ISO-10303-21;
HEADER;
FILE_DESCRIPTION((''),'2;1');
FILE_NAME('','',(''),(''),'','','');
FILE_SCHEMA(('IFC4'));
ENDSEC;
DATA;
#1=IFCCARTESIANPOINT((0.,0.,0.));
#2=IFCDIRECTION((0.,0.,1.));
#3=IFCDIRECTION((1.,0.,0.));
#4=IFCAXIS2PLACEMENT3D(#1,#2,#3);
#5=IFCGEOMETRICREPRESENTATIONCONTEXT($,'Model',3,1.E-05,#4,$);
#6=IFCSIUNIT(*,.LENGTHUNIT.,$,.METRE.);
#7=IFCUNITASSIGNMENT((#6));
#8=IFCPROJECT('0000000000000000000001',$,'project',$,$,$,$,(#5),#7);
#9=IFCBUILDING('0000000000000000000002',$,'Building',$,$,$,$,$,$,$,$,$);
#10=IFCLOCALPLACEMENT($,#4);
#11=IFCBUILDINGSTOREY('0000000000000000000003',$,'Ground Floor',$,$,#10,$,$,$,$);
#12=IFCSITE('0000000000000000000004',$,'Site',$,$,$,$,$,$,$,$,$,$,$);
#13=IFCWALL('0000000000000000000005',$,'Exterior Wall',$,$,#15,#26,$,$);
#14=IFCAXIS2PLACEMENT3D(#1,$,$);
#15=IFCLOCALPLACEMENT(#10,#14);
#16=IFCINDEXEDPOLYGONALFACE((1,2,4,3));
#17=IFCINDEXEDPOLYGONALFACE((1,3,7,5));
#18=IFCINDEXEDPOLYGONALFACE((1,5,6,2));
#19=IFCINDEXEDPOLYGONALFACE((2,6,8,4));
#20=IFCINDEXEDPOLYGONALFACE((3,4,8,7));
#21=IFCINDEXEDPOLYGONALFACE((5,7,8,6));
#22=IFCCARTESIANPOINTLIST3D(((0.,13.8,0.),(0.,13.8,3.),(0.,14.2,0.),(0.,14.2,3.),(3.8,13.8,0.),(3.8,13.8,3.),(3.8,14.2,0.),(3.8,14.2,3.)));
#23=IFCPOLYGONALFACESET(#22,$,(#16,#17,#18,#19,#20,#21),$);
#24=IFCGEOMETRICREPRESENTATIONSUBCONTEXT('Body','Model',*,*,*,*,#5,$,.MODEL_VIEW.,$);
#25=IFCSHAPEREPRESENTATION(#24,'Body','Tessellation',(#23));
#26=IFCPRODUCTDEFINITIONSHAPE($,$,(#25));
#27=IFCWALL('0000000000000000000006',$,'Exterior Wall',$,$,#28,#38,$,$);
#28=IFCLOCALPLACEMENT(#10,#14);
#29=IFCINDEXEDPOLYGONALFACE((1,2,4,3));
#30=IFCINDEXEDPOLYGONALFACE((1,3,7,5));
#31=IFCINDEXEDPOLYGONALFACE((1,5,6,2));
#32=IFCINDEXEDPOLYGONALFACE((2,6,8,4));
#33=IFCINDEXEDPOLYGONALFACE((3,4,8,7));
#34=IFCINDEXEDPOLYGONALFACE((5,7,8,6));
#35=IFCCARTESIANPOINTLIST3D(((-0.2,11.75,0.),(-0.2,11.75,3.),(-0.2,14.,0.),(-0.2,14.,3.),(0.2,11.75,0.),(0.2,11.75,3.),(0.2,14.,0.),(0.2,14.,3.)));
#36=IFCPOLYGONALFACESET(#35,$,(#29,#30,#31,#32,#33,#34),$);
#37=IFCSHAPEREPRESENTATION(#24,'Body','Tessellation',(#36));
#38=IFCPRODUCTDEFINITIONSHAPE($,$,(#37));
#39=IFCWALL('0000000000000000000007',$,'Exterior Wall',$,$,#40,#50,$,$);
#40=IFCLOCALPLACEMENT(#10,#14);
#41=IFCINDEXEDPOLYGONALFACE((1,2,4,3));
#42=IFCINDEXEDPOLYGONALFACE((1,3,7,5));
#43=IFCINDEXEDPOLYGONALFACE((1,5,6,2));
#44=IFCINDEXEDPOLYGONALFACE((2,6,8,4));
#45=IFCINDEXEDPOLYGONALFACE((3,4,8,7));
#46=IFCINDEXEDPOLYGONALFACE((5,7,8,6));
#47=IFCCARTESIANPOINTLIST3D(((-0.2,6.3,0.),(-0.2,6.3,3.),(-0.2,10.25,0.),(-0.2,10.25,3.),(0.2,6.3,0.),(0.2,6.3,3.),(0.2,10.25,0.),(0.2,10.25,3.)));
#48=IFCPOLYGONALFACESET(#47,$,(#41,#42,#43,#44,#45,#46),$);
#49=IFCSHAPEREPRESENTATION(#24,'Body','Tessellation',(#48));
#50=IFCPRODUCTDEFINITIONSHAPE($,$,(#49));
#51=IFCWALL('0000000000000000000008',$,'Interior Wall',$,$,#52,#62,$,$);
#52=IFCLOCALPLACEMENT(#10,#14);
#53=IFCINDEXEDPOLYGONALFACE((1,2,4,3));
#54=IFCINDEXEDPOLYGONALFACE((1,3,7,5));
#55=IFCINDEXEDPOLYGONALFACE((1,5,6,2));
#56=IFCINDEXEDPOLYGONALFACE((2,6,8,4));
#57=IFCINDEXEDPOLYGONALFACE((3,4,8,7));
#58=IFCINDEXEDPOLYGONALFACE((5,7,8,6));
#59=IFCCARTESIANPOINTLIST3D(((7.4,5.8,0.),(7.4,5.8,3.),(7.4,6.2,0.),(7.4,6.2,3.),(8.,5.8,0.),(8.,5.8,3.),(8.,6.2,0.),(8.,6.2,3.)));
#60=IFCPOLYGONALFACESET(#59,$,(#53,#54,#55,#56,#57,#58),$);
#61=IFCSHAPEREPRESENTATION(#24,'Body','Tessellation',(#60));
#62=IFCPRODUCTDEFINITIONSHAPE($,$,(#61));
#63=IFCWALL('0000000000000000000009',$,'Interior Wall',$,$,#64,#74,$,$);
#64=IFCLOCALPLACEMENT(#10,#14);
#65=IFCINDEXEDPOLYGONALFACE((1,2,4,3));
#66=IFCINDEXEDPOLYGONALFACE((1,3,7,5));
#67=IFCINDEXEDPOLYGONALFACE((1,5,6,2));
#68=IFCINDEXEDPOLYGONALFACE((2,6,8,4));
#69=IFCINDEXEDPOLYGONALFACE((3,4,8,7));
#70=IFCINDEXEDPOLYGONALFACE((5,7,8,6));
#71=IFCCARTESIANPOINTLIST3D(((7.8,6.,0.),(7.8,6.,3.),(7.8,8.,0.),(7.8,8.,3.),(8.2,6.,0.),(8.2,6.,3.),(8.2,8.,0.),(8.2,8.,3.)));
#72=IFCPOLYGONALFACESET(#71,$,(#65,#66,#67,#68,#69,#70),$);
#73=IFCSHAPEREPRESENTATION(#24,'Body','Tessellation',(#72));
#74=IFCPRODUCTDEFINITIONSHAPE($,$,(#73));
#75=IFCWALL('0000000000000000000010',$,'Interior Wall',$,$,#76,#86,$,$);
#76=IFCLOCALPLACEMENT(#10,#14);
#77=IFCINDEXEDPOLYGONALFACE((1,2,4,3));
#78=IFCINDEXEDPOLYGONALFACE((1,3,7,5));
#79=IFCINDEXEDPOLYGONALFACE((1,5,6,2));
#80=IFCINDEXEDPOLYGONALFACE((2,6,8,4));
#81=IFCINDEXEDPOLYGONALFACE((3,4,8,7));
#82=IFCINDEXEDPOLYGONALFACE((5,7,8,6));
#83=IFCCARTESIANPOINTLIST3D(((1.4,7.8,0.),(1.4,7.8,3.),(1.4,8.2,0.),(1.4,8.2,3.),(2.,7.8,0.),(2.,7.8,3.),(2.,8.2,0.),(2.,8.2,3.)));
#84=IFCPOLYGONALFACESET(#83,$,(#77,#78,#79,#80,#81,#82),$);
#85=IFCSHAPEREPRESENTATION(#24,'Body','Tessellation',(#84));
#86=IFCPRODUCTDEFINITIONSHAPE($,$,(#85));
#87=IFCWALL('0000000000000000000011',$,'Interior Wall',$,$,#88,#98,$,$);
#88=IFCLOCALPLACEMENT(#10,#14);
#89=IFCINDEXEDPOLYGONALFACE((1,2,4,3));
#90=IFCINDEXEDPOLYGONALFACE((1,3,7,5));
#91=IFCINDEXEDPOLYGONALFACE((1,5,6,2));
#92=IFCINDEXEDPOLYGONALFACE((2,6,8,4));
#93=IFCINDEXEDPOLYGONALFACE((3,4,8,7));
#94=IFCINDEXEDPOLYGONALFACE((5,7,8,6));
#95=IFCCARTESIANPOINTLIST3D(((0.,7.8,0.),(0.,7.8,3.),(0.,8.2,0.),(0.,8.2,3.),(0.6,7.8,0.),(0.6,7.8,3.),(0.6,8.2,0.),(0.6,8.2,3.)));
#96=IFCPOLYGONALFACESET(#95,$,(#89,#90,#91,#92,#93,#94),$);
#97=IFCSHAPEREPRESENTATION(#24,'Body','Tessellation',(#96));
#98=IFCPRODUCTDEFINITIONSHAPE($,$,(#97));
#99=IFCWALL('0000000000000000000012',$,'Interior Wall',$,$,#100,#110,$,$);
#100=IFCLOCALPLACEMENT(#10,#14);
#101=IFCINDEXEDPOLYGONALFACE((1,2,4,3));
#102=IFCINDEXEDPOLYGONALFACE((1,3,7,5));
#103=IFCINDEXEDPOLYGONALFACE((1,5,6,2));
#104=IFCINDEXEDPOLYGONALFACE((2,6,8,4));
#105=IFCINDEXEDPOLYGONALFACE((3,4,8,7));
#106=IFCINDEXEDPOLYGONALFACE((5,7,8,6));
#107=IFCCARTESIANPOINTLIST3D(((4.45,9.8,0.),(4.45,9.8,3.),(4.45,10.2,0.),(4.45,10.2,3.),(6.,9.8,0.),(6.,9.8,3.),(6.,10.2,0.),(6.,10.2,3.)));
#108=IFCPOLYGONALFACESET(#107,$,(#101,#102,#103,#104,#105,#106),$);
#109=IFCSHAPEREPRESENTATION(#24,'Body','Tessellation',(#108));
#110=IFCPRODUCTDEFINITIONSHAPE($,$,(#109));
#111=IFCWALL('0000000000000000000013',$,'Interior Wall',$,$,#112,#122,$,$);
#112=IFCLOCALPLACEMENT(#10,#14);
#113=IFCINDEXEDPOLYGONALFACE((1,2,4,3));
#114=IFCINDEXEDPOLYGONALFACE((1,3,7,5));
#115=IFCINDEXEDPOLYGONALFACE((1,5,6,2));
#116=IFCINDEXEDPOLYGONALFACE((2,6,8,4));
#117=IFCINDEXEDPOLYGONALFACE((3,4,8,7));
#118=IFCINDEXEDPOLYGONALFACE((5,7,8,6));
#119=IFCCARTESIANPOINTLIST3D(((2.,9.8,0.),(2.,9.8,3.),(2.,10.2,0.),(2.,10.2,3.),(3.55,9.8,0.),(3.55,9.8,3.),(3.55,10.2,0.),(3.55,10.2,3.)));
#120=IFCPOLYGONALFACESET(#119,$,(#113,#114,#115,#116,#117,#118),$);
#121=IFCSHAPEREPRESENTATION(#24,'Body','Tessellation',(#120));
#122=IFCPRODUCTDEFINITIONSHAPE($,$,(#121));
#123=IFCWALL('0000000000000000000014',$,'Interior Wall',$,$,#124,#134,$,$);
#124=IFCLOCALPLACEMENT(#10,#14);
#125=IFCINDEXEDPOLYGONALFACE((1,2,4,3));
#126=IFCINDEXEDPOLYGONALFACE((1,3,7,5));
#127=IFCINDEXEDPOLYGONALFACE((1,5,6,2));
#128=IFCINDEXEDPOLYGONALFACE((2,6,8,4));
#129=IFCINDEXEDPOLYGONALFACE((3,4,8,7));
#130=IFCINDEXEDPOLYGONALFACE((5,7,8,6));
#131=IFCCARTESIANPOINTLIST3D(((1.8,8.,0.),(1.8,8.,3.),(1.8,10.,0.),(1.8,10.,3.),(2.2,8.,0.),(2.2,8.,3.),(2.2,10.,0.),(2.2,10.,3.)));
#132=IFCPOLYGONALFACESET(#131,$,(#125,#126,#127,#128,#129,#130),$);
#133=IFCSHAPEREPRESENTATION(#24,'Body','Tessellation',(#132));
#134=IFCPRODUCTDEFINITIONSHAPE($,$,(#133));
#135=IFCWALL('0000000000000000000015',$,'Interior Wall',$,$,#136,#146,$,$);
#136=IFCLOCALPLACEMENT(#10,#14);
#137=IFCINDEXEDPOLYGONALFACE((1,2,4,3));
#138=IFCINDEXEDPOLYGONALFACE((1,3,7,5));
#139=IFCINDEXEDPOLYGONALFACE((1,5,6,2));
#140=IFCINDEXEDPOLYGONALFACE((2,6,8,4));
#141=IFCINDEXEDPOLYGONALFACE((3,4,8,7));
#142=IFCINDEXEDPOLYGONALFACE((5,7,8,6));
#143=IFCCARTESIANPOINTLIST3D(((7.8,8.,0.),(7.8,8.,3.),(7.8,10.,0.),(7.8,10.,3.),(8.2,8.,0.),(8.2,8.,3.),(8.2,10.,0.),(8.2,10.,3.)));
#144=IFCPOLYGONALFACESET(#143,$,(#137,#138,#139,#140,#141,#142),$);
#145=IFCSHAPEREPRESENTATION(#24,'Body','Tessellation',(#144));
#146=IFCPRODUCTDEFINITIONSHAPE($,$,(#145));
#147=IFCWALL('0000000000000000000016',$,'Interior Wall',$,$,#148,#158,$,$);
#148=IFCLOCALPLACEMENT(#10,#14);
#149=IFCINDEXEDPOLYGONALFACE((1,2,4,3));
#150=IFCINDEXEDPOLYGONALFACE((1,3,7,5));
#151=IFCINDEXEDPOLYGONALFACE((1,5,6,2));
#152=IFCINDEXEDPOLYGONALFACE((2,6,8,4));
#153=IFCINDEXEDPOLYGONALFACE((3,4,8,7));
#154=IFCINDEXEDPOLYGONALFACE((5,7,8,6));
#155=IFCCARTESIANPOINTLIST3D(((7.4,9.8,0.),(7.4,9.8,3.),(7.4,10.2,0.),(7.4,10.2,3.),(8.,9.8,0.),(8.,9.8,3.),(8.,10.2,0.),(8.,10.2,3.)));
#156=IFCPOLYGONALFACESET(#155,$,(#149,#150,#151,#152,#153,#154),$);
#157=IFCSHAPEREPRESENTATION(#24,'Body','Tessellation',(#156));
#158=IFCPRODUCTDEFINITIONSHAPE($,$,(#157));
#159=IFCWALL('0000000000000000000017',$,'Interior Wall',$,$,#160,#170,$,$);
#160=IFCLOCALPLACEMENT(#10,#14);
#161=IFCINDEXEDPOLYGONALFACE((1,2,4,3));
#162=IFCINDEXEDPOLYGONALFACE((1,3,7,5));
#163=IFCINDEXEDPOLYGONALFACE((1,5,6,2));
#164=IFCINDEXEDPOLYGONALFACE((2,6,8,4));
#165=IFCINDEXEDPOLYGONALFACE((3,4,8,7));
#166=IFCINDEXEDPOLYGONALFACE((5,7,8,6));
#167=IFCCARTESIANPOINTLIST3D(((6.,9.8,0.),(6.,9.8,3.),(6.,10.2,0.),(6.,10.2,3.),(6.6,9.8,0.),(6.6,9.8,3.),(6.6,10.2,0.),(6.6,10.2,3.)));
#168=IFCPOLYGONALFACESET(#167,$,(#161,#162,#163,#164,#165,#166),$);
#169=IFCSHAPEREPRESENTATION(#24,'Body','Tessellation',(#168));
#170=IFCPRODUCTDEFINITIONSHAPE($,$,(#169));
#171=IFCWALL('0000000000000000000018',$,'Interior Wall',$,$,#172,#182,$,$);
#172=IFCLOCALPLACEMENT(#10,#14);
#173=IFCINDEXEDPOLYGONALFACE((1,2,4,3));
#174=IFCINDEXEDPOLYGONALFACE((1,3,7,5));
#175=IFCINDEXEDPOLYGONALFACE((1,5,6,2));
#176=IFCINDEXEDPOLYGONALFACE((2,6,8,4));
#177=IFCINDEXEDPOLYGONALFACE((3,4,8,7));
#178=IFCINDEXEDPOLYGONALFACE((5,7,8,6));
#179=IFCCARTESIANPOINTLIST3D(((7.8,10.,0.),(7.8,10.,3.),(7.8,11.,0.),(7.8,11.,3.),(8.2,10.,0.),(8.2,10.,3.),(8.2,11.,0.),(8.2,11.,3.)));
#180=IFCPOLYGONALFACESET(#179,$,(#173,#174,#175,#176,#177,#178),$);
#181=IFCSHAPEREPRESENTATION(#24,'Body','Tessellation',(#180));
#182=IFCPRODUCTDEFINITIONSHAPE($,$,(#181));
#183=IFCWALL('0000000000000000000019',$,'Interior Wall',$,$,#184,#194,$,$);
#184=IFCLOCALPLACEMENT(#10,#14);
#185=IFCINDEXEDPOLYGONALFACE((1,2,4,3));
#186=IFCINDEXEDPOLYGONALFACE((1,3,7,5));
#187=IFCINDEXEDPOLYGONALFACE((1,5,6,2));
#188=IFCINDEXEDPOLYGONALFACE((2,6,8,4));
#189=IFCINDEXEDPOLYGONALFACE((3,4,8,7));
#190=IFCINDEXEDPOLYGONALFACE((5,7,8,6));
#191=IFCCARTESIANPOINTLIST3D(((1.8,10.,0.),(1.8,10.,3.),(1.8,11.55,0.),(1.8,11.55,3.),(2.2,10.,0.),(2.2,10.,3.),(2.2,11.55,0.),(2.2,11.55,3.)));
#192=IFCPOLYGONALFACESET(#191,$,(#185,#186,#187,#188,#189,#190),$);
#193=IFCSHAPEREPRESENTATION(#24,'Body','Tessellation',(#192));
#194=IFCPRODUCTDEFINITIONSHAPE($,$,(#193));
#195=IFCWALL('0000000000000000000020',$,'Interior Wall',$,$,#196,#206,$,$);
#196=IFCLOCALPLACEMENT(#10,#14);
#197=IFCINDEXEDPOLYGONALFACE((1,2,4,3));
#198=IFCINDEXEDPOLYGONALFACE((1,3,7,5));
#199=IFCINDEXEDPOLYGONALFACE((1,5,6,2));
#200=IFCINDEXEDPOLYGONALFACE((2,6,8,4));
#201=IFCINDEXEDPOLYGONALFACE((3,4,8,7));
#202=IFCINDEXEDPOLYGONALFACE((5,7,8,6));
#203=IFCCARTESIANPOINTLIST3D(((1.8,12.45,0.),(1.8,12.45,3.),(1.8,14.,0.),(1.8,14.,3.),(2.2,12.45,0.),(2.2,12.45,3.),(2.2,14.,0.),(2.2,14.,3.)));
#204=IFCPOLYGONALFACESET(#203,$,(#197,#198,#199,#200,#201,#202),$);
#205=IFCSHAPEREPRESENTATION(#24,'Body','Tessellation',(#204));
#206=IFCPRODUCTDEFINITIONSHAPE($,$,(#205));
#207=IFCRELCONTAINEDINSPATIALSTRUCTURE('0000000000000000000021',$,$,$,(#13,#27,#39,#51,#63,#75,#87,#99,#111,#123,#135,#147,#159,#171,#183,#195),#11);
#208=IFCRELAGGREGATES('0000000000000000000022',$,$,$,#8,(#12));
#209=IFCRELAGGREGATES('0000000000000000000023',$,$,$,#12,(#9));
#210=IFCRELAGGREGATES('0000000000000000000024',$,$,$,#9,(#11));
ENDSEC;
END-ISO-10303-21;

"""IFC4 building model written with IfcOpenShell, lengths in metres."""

from ifc_helpers import new_model, si_unit, frame, origin_with_axes, place, context, subcontext, project, spatial, indexed_curve, outline, extrude, element, save


model = new_model("IFC4")

# Units and contexts
model_context = context("Model", 3, precision=1e-05, world=origin_with_axes())
body_context = subcontext(model_context, "Body", "Model", "MODEL_VIEW")
ifc_project = project(units=[si_unit("LENGTHUNIT", "METRE")], contexts=[model_context])

# Site, building, storey
site = spatial("IfcSite", under=ifc_project, Name="Site")
building = spatial("IfcBuilding", under=site, Name="Building")
storey_placement = place(None, origin_with_axes())
storey = spatial("IfcBuildingStorey", under=building, at=storey_placement, Name="Ground Floor")

# Walls
wall_1_placement = place(storey_placement, frame((3.8, 14.0, 0.0), z_axis=(0.0, 0.0, 1.0), x_axis=(-1.0, 0.0, 0.0)))
element("IfcWall", 1, at=wall_1_placement, inside=storey, Name="Exterior Wall", context=body_context, shape_type="SweptSolid", body=[
    extrude(outline(indexed_curve([(0.0, 0.0), (0.0, 0.4), (3.8, 0.4), (3.8, 0.0), (0.0, 0.0)], self_intersect=False)), frame((0.0, -0.2, 0.0), z_axis=(0.0, 0.0, 1.0), x_axis=(1.0, 0.0, 0.0)), (0.0, 0.0, 1.0), 3.0),
])
wall_2_placement = place(storey_placement, frame((0.0, 14.0, 0.0), z_axis=(0.0, 0.0, 1.0), x_axis=(0.0, -1.0, 0.0)))
element("IfcWall", 2, at=wall_2_placement, inside=storey, Name="Exterior Wall", context=body_context, shape_type="SweptSolid", body=[
    extrude(outline(indexed_curve([(0.0, 0.0), (0.0, 0.4), (2.25, 0.4), (2.25, 0.0), (0.0, 0.0)], self_intersect=False)), frame((0.0, -0.2, 0.0), z_axis=(0.0, 0.0, 1.0), x_axis=(1.0, 0.0, 0.0)), (0.0, 0.0, 1.0), 3.0),
])
wall_3_placement = place(storey_placement, frame((0.0, 10.25, 0.0), z_axis=(0.0, 0.0, 1.0), x_axis=(0.0, -1.0, 0.0)))
element("IfcWall", 3, at=wall_3_placement, inside=storey, Name="Exterior Wall", context=body_context, shape_type="SweptSolid", body=[
    extrude(outline(indexed_curve([(0.0, 0.0), (0.0, 0.4), (3.95, 0.4), (3.95, 0.0), (0.0, 0.0)], self_intersect=False)), frame((0.0, -0.2, 0.0), z_axis=(0.0, 0.0, 1.0), x_axis=(1.0, 0.0, 0.0)), (0.0, 0.0, 1.0), 3.0),
])
wall_4_placement = place(storey_placement, frame((8.0, 6.0, 0.0), z_axis=(0.0, 0.0, 1.0), x_axis=(-1.0, 0.0, 0.0)))
element("IfcWall", 4, at=wall_4_placement, inside=storey, Name="Interior Wall", context=body_context, shape_type="SweptSolid", body=[
    extrude(outline(indexed_curve([(0.0, 0.0), (0.0, 0.4), (0.6, 0.4), (0.6, 0.0), (0.0, 0.0)], self_intersect=False)), frame((0.0, -0.2, 0.0), z_axis=(0.0, 0.0, 1.0), x_axis=(1.0, 0.0, 0.0)), (0.0, 0.0, 1.0), 3.0),
])
wall_5_placement = place(storey_placement, frame((8.0, 8.0, 0.0), z_axis=(0.0, 0.0, 1.0), x_axis=(0.0, -1.0, 0.0)))
element("IfcWall", 5, at=wall_5_placement, inside=storey, Name="Interior Wall", context=body_context, shape_type="SweptSolid", body=[
    extrude(outline(indexed_curve([(0.0, 0.0), (0.0, 0.4), (2.0, 0.4), (2.0, 0.0), (0.0, 0.0)], self_intersect=False)), frame((0.0, -0.2, 0.0), z_axis=(0.0, 0.0, 1.0), x_axis=(1.0, 0.0, 0.0)), (0.0, 0.0, 1.0), 3.0),
])
for number, where, z_axis, x_axis, name in (
    (6, (2.0, 8.0, 0.0), (0.0, 0.0, 1.0), (-1.0, 0.0, 0.0), "Interior Wall"),
    (7, (0.6, 8.0, 0.0), (0.0, 0.0, 1.0), (-1.0, 0.0, 0.0), "Interior Wall"),
):
    element("IfcWall", number, at=place(storey_placement, frame(where, z_axis=z_axis, x_axis=x_axis)), inside=storey, Name=name, context=body_context, shape_type="SweptSolid", body=[
        extrude(outline(indexed_curve([(0.0, 0.0), (0.0, 0.4), (0.6, 0.4), (0.6, 0.0), (0.0, 0.0)], self_intersect=False)), frame((0.0, -0.2, 0.0), z_axis=(0.0, 0.0, 1.0), x_axis=(1.0, 0.0, 0.0)), (0.0, 0.0, 1.0), 3.0),
    ])
for number, where, z_axis, x_axis, name in (
    (8, (6.0, 10.0, 0.0), (0.0, 0.0, 1.0), (-1.0, 0.0, 0.0), "Interior Wall"),
    (9, (3.55, 10.0, 0.0), (0.0, 0.0, 1.0), (-1.0, 0.0, 0.0), "Interior Wall"),
):
    element("IfcWall", number, at=place(storey_placement, frame(where, z_axis=z_axis, x_axis=x_axis)), inside=storey, Name=name, context=body_context, shape_type="SweptSolid", body=[
        extrude(outline(indexed_curve([(0.0, 0.0), (0.0, 0.4), (1.55, 0.4), (1.55, 0.0), (0.0, 0.0)], self_intersect=False)), frame((0.0, -0.2, 0.0), z_axis=(0.0, 0.0, 1.0), x_axis=(1.0, 0.0, 0.0)), (0.0, 0.0, 1.0), 3.0),
    ])
for number, where, z_axis, x_axis, name in (
    (10, (2.0, 10.0, 0.0), (0.0, 0.0, 1.0), (0.0, -1.0, 0.0), "Interior Wall"),
    (11, (8.0, 8.0, 0.0), (0.0, 0.0, 1.0), (0.0, 1.0, 0.0), "Interior Wall"),
):
    element("IfcWall", number, at=place(storey_placement, frame(where, z_axis=z_axis, x_axis=x_axis)), inside=storey, Name=name, context=body_context, shape_type="SweptSolid", body=[
        extrude(outline(indexed_curve([(0.0, 0.0), (0.0, 0.4), (2.0, 0.4), (2.0, 0.0), (0.0, 0.0)], self_intersect=False)), frame((0.0, -0.2, 0.0), z_axis=(0.0, 0.0, 1.0), x_axis=(1.0, 0.0, 0.0)), (0.0, 0.0, 1.0), 3.0),
    ])
for number, where, z_axis, x_axis, name in (
    (12, (8.0, 10.0, 0.0), (0.0, 0.0, 1.0), (-1.0, 0.0, 0.0), "Interior Wall"),
    (13, (6.6, 10.0, 0.0), (0.0, 0.0, 1.0), (-1.0, 0.0, 0.0), "Interior Wall"),
):
    element("IfcWall", number, at=place(storey_placement, frame(where, z_axis=z_axis, x_axis=x_axis)), inside=storey, Name=name, context=body_context, shape_type="SweptSolid", body=[
        extrude(outline(indexed_curve([(0.0, 0.0), (0.0, 0.4), (0.6, 0.4), (0.6, 0.0), (0.0, 0.0)], self_intersect=False)), frame((0.0, -0.2, 0.0), z_axis=(0.0, 0.0, 1.0), x_axis=(1.0, 0.0, 0.0)), (0.0, 0.0, 1.0), 3.0),
    ])
wall_6_placement = place(storey_placement, frame((8.0, 11.0, 0.0), z_axis=(0.0, 0.0, 1.0), x_axis=(0.0, -1.0, 0.0)))
element("IfcWall", 14, at=wall_6_placement, inside=storey, Name="Interior Wall", context=body_context, shape_type="SweptSolid", body=[
    extrude(outline(indexed_curve([(0.0, 0.0), (0.0, 0.4), (1.0, 0.4), (1.0, 0.0), (0.0, 0.0)], self_intersect=False)), frame((0.0, -0.2, 0.0), z_axis=(0.0, 0.0, 1.0), x_axis=(1.0, 0.0, 0.0)), (0.0, 0.0, 1.0), 3.0),
])
for number, where, z_axis, x_axis, name in (
    (15, (2.0, 10.0, 0.0), (0.0, 0.0, 1.0), (0.0, 1.0, 0.0), "Interior Wall"),
    (16, (2.0, 12.45, 0.0), (0.0, 0.0, 1.0), (0.0, 1.0, 0.0), "Interior Wall"),
):
    element("IfcWall", number, at=place(storey_placement, frame(where, z_axis=z_axis, x_axis=x_axis)), inside=storey, Name=name, context=body_context, shape_type="SweptSolid", body=[
        extrude(outline(indexed_curve([(0.0, 0.0), (0.0, 0.4), (1.55, 0.4), (1.55, 0.0), (0.0, 0.0)], self_intersect=False)), frame((0.0, -0.2, 0.0), z_axis=(0.0, 0.0, 1.0), x_axis=(1.0, 0.0, 0.0)), (0.0, 0.0, 1.0), 3.0),
    ])

save(model, "model.ifc")
